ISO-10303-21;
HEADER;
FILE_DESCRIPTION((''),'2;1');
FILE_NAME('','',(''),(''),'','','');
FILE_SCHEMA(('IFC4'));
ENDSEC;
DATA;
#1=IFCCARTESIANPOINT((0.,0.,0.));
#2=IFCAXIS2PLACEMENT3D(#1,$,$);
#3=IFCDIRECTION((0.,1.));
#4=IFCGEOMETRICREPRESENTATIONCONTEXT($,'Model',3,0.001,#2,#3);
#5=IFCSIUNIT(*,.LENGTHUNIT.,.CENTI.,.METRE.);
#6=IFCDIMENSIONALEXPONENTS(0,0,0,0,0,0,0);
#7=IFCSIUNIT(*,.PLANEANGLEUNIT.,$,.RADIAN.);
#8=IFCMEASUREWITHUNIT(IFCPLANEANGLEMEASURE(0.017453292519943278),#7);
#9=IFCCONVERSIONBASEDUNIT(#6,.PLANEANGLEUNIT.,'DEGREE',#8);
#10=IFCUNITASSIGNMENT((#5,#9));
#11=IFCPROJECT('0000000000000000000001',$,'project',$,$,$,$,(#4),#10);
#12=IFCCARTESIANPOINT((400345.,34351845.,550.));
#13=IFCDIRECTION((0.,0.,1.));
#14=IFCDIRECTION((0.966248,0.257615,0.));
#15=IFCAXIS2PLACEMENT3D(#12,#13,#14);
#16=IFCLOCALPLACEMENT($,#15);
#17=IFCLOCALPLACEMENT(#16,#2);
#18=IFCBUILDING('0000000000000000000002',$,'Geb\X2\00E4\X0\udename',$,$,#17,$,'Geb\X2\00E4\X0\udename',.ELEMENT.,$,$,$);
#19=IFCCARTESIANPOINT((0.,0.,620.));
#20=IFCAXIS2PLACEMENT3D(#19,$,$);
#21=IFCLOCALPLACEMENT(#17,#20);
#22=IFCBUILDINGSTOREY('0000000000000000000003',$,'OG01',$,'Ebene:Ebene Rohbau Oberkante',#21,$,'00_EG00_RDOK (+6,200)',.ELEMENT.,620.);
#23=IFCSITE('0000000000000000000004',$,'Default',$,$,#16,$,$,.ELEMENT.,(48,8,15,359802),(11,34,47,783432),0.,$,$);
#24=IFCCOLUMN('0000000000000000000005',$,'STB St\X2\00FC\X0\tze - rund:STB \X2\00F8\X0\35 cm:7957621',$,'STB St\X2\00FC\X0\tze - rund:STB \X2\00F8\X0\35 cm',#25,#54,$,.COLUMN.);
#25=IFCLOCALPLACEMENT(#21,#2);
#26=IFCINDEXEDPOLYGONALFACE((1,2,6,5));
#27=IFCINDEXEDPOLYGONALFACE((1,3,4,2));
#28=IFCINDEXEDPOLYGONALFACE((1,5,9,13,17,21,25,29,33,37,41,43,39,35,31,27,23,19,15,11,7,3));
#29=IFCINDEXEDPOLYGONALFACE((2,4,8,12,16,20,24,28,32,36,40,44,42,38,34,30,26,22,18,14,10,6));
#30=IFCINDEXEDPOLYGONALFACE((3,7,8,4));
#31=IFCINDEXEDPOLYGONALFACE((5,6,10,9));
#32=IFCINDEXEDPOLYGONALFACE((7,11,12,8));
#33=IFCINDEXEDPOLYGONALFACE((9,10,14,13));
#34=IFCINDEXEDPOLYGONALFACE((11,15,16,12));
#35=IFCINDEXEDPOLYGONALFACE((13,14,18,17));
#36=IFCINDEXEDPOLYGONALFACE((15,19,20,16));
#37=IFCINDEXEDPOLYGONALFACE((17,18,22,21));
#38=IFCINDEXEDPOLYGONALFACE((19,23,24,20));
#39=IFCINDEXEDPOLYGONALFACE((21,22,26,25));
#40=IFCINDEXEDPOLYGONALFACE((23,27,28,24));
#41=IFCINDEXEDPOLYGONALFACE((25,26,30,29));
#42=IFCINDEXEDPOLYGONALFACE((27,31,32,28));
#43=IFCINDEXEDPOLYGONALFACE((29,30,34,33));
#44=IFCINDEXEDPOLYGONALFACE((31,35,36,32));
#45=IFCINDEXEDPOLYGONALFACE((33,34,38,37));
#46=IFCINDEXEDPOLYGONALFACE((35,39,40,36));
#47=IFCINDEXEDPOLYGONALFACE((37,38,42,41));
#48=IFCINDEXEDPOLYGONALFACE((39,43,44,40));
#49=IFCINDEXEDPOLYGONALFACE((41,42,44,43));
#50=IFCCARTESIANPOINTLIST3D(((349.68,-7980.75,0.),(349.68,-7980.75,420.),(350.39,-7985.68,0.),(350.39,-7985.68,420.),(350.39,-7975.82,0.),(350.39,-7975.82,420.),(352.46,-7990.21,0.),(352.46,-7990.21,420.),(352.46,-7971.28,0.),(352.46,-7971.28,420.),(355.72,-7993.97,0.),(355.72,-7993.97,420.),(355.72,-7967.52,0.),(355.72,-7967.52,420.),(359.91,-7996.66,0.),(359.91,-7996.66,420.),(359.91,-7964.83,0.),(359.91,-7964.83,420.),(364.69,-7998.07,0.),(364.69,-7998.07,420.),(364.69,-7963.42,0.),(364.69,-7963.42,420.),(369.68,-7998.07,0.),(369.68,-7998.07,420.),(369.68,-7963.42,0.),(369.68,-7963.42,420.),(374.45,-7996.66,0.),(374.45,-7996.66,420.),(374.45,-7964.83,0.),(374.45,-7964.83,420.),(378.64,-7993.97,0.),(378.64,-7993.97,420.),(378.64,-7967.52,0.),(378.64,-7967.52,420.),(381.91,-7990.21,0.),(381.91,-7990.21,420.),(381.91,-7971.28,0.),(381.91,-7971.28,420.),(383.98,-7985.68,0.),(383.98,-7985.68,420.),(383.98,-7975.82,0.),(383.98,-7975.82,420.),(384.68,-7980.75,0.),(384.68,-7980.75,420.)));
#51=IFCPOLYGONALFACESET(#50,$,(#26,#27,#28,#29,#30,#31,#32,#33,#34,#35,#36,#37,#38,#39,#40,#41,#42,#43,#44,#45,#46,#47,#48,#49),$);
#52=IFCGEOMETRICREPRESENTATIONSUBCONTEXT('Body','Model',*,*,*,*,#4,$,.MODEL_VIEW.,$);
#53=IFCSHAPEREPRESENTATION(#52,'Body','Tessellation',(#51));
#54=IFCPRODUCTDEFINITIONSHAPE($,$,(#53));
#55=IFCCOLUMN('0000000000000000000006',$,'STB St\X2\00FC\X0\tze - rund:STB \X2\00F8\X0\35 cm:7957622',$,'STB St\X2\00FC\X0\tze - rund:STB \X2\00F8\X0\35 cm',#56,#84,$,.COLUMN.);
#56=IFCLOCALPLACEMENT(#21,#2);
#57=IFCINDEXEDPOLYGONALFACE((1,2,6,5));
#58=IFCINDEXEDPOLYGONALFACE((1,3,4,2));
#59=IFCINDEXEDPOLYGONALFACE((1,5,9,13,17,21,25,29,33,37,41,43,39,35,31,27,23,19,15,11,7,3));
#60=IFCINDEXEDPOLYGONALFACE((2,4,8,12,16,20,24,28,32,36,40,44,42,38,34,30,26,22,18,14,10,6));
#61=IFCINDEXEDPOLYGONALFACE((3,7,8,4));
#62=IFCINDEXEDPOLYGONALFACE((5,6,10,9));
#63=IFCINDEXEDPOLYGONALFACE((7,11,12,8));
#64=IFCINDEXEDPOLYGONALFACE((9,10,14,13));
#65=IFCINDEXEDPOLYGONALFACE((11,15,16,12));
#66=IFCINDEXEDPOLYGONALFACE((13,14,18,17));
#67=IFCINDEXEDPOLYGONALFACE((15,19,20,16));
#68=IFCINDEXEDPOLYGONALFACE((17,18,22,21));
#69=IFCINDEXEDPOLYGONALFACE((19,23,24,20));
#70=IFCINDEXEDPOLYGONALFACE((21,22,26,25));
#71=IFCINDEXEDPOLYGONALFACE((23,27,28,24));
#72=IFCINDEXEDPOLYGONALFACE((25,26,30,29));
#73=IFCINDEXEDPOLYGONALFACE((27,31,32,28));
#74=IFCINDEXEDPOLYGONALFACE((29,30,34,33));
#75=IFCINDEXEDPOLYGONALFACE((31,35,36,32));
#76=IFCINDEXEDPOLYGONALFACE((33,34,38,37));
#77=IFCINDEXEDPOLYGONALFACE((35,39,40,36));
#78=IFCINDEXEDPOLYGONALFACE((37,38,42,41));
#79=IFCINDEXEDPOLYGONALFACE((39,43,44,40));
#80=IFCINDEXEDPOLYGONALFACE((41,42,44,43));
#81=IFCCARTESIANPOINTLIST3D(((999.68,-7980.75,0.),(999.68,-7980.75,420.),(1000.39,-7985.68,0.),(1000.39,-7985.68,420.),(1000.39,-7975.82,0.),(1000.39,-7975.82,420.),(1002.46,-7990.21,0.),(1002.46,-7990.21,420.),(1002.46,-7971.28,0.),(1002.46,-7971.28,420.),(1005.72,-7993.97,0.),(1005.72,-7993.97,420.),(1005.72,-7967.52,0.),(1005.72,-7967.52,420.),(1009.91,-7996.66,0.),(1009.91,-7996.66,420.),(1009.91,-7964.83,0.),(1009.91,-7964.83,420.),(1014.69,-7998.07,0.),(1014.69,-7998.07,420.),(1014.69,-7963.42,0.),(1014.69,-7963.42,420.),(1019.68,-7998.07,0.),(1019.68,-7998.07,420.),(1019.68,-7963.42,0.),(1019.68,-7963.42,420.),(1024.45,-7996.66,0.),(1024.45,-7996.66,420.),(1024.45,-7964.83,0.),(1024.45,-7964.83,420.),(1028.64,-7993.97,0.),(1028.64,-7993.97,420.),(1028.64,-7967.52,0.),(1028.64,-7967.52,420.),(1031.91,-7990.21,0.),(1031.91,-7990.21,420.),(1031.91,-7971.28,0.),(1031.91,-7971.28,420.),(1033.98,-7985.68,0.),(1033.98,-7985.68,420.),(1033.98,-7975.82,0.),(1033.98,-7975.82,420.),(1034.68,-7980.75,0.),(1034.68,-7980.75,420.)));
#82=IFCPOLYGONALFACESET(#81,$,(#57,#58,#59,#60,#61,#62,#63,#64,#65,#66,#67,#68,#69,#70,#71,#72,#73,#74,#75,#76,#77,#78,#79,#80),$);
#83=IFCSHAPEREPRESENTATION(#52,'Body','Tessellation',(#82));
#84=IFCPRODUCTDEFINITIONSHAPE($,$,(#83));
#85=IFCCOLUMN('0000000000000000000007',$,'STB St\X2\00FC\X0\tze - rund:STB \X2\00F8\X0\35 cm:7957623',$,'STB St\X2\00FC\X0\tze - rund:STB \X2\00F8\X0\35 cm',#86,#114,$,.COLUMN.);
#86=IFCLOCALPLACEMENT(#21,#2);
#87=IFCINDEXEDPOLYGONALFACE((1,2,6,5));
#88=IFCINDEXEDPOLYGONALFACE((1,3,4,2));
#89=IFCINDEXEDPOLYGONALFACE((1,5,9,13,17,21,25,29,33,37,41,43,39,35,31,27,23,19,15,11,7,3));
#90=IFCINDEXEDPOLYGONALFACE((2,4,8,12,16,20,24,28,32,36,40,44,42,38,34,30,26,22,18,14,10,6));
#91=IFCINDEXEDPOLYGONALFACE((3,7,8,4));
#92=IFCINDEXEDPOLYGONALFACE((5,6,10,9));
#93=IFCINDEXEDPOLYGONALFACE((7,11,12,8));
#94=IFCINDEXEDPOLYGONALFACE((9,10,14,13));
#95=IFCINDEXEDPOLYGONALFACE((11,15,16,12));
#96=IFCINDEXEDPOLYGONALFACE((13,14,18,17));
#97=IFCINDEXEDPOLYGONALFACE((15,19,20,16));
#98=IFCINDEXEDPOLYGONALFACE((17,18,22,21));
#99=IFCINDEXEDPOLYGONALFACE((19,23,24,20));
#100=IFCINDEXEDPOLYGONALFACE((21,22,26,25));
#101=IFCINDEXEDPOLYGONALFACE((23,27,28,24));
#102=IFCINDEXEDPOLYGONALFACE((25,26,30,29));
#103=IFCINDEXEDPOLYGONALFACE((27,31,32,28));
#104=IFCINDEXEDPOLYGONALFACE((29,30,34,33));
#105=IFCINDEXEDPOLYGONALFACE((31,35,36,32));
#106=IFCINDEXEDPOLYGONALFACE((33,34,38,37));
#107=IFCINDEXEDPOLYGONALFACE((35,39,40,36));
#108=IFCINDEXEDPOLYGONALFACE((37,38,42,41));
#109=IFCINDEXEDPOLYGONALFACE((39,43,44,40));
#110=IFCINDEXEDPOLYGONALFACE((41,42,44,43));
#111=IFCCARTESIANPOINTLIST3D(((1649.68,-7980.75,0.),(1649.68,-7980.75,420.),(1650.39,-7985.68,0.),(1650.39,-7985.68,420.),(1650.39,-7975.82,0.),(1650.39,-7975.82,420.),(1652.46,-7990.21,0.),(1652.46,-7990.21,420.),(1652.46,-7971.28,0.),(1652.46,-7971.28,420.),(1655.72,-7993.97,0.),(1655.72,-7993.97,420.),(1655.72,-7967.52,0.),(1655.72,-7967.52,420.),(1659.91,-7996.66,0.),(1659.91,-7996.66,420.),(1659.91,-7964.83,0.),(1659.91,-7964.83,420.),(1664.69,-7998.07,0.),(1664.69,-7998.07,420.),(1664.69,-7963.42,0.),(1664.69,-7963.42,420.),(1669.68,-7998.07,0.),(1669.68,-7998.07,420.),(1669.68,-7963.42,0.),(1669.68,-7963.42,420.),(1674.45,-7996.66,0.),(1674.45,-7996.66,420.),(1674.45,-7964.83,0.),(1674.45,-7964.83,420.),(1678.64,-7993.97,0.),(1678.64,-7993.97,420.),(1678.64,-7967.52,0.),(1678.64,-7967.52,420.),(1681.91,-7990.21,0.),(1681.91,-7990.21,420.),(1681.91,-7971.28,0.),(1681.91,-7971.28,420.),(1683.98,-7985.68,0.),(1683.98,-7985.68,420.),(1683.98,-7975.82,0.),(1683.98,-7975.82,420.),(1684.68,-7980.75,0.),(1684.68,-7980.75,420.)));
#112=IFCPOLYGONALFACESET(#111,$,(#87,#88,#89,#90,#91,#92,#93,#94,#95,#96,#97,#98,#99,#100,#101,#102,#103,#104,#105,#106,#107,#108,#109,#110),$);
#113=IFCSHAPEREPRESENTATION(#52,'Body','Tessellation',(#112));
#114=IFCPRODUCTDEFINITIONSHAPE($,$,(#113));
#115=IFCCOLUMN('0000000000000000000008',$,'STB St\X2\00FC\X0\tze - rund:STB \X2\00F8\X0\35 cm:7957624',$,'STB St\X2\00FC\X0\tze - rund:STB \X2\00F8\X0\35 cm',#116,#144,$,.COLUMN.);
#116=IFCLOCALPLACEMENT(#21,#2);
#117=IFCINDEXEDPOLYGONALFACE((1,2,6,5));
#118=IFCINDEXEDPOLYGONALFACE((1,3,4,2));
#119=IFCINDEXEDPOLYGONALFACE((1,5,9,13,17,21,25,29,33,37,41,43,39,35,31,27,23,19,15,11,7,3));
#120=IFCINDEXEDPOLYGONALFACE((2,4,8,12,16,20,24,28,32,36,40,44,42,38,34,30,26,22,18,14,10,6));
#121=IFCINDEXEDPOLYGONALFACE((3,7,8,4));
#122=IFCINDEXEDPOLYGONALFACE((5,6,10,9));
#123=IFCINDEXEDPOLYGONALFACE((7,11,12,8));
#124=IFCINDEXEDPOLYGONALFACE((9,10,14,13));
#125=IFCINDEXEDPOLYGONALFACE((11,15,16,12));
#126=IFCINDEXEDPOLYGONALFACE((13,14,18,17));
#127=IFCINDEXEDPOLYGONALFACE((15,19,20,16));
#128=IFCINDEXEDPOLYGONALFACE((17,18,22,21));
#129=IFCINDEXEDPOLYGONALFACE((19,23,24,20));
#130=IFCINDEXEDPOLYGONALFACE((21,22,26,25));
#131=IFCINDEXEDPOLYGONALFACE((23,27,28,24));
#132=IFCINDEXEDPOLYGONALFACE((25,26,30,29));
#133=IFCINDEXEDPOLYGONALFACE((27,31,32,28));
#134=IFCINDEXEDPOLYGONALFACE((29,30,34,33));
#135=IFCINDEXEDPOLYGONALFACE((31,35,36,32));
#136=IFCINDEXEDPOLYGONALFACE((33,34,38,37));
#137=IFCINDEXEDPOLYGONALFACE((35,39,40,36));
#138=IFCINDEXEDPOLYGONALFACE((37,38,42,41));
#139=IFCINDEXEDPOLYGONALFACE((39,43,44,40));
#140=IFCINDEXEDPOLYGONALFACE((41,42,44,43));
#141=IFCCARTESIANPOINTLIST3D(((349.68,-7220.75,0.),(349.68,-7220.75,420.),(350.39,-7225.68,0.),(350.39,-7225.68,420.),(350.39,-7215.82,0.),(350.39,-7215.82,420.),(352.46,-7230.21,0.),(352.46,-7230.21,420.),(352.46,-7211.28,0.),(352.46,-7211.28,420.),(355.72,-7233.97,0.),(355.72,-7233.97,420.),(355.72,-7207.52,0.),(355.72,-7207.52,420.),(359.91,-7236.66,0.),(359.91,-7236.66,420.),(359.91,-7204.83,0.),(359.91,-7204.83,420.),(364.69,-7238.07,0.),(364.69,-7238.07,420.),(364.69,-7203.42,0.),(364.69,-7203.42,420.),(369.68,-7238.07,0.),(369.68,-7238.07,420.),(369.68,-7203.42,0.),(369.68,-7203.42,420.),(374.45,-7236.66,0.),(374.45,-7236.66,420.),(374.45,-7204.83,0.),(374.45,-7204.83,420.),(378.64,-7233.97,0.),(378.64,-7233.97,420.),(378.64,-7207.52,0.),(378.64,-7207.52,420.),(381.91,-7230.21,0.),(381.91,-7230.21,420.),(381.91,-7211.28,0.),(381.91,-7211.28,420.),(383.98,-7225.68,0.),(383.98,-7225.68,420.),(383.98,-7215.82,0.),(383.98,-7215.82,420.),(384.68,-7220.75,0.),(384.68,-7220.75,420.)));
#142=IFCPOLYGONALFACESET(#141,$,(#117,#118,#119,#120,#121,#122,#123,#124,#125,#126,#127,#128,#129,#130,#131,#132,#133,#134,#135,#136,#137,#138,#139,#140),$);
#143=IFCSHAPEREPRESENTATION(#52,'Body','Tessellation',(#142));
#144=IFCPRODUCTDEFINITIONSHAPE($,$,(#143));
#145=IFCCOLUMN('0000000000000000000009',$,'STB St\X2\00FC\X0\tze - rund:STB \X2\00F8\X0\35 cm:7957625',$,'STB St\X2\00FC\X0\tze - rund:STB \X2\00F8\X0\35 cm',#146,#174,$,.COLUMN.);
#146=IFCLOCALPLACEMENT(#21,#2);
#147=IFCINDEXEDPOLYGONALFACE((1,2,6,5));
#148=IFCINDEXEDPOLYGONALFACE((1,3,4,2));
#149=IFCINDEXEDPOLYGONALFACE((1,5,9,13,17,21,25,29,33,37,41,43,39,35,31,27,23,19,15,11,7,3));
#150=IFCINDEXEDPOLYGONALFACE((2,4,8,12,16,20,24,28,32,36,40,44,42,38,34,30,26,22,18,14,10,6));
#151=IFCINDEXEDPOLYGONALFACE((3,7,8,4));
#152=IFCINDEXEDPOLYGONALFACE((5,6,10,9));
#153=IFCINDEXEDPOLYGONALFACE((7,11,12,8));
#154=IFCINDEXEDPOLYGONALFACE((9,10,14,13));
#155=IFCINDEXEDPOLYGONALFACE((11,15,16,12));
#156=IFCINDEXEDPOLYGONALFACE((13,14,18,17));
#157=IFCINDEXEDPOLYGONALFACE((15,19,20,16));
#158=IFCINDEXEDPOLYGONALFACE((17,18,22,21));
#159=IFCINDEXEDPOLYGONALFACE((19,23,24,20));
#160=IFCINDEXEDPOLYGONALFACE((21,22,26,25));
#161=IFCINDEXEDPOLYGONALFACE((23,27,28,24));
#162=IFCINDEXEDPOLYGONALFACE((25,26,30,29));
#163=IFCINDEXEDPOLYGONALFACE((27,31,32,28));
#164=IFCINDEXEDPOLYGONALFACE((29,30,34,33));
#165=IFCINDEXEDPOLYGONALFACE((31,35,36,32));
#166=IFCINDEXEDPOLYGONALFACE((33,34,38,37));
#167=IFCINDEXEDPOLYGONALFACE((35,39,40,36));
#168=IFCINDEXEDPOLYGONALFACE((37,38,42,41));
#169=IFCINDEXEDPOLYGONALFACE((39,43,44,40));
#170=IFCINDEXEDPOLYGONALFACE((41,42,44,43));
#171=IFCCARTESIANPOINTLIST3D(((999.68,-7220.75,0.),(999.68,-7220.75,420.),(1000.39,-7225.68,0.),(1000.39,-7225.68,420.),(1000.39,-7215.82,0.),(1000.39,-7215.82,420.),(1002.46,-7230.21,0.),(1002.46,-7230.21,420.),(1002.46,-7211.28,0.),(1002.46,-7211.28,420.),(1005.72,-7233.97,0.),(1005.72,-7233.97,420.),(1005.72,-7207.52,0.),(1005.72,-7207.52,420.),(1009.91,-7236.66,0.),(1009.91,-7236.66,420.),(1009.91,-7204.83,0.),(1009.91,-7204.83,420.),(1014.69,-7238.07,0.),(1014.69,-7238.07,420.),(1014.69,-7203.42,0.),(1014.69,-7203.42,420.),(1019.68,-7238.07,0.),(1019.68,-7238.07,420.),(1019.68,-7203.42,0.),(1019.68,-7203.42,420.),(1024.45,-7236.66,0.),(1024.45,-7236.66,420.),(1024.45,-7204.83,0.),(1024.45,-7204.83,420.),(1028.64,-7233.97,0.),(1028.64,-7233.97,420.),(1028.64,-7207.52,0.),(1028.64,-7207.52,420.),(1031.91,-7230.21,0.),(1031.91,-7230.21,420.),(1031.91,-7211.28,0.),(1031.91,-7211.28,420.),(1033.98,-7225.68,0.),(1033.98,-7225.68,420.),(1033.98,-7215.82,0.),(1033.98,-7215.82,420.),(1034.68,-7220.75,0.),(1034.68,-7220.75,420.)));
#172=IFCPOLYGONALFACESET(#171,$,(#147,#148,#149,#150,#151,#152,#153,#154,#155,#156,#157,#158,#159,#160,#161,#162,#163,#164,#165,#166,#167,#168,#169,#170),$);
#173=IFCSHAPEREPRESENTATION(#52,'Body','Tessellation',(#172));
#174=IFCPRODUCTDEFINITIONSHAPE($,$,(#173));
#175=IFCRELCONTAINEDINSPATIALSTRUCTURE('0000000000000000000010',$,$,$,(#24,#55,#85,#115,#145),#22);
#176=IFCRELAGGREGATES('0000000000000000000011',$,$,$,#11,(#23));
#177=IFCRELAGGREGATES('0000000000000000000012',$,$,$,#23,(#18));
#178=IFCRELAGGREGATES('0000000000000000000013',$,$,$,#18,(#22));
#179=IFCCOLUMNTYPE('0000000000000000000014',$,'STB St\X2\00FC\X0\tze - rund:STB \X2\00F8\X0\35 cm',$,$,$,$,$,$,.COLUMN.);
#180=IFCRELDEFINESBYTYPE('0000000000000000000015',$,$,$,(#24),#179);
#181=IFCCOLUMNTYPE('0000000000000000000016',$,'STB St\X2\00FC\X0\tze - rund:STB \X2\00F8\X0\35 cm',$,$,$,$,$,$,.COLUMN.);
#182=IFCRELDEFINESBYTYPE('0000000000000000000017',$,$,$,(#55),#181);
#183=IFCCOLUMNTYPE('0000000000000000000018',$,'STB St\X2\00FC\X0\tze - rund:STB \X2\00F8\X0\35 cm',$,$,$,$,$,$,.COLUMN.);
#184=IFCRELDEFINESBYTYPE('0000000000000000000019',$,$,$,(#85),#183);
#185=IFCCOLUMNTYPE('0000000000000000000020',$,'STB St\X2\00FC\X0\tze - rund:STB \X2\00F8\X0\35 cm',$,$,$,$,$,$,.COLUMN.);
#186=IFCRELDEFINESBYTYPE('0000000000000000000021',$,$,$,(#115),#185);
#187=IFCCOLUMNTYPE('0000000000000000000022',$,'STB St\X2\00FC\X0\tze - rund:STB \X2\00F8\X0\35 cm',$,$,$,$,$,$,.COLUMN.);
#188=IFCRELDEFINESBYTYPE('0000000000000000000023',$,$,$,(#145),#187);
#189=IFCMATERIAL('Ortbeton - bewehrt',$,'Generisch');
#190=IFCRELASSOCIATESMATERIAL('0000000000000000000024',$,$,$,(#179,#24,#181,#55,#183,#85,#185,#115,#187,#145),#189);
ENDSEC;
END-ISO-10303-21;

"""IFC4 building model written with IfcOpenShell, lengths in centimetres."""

from ifc_helpers import new_model, entity, si_unit, converted_unit, direction, frame, origin, place, context, subcontext, project, spatial, arc, indexed_curve, outline, extrude, source, transform, mapped, material, type_object, type_shapes, element, save


model = new_model("IFC4")

# Units and contexts
model_context = context("Model", 3, precision=0.001, world=origin(), true_north=direction((0.0, 1.0)))
body_context = subcontext(model_context, "Body", "Model", "MODEL_VIEW")
ifc_project = project(units=[si_unit("LENGTHUNIT", "METRE", prefix="CENTI"), converted_unit("PLANEANGLEUNIT", "DEGREE", entity("IfcPlaneAngleMeasure", 0.017453292519943278), si_unit("PLANEANGLEUNIT", "RADIAN"), dimensions=[0, 0, 0, 0, 0, 0, 0])], contexts=[model_context])

# Site, building, storey
site_placement = place(None, frame((400345.0, 34351845.0, 550.0), z_axis=(0.0, 0.0, 1.0), x_axis=(0.966248, 0.257615, 0.0)))
site = spatial("IfcSite", under=ifc_project, at=site_placement, Name="Default", CompositionType="ELEMENT", RefLatitude=(48, 8, 15, 359802), RefLongitude=(11, 34, 47, 783432), RefElevation=0.0)
building_placement = place(site_placement, origin())
building = spatial("IfcBuilding", under=site, at=building_placement, Name="Gebäudename", LongName="Gebäudename", CompositionType="ELEMENT")
storey_placement = place(building_placement, frame((0.0, 0.0, 620.0)))
storey = spatial("IfcBuildingStorey", under=building, at=storey_placement, Name="OG01", ObjectType="Ebene:Ebene Rohbau Oberkante", LongName="00_EG00_RDOK (+6,200)", CompositionType="ELEMENT", Elevation=620.0)

# Columns
ifc_material = material(Name="Ortbeton - bewehrt", Category="Generisch")
column_type_1 = type_object("IfcColumnType", Name="STB Stütze - rund:STB ø35 cm", PredefinedType="COLUMN", material=ifc_material)
shared_shape_1 = source(origin(), body_context, "Body", "SweptSolid", [
    extrude(outline(indexed_curve([(-17.5, 0.0), (0.0, -17.5), (17.5, 0.0), (0.0, 17.5)], segments=[arc(1, 2, 3), arc(3, 4, 1)], self_intersect=False)), frame((367.18, -7980.75, 620.0)), (0.0, 0.0, 1.0), 420.0),
])
type_shapes(column_type_1, [shared_shape_1])
column_1_placement = place(storey_placement, frame((0.0, 0.0, -620.0)))
element("IfcColumn", 1, at=column_1_placement, inside=storey, type_object=column_type_1, material=ifc_material, Name="STB Stütze - rund:STB ø35 cm:7957621", ObjectType="STB Stütze - rund:STB ø35 cm", PredefinedType="COLUMN", context=body_context, shape_type="MappedRepresentation", body=[
    mapped(shared_shape_1, transform((0.0, 0.0, 0.0), scale=1.0)),
])
column_type_2 = type_object("IfcColumnType", Name="STB Stütze - rund:STB ø35 cm", PredefinedType="COLUMN", material=ifc_material)
shared_shape_2 = source(origin(), body_context, "Body", "SweptSolid", [
    extrude(outline(indexed_curve([(-17.5, 0.0), (0.0, -17.5), (17.5, 0.0), (0.0, 17.5)], segments=[arc(1, 2, 3), arc(3, 4, 1)], self_intersect=False)), frame((1017.18, -7980.75, 620.0)), (0.0, 0.0, 1.0), 420.0),
])
type_shapes(column_type_2, [shared_shape_2])
column_2_placement = place(storey_placement, frame((0.0, 0.0, -620.0)))
element("IfcColumn", 2, at=column_2_placement, inside=storey, type_object=column_type_2, material=ifc_material, Name="STB Stütze - rund:STB ø35 cm:7957622", ObjectType="STB Stütze - rund:STB ø35 cm", PredefinedType="COLUMN", context=body_context, shape_type="MappedRepresentation", body=[
    mapped(shared_shape_2, transform((0.0, 0.0, 0.0), scale=1.0)),
])
column_type_3 = type_object("IfcColumnType", Name="STB Stütze - rund:STB ø35 cm", PredefinedType="COLUMN", material=ifc_material)
shared_shape_3 = source(origin(), body_context, "Body", "SweptSolid", [
    extrude(outline(indexed_curve([(-17.5, 0.0), (0.0, -17.5), (17.5, 0.0), (0.0, 17.5)], segments=[arc(1, 2, 3), arc(3, 4, 1)], self_intersect=False)), frame((1667.18, -7980.75, 620.0)), (0.0, 0.0, 1.0), 420.0),
])
type_shapes(column_type_3, [shared_shape_3])
column_3_placement = place(storey_placement, frame((0.0, 0.0, -620.0)))
element("IfcColumn", 3, at=column_3_placement, inside=storey, type_object=column_type_3, material=ifc_material, Name="STB Stütze - rund:STB ø35 cm:7957623", ObjectType="STB Stütze - rund:STB ø35 cm", PredefinedType="COLUMN", context=body_context, shape_type="MappedRepresentation", body=[
    mapped(shared_shape_3, transform((0.0, 0.0, 0.0), scale=1.0)),
])
column_type_4 = type_object("IfcColumnType", Name="STB Stütze - rund:STB ø35 cm", PredefinedType="COLUMN", material=ifc_material)
shared_shape_4 = source(origin(), body_context, "Body", "SweptSolid", [
    extrude(outline(indexed_curve([(-17.5, 0.0), (0.0, -17.5), (17.5, 0.0), (0.0, 17.5)], segments=[arc(1, 2, 3), arc(3, 4, 1)], self_intersect=False)), frame((367.18, -7220.75, 620.0)), (0.0, 0.0, 1.0), 420.0),
])
type_shapes(column_type_4, [shared_shape_4])
column_4_placement = place(storey_placement, frame((0.0, 0.0, -620.0)))
element("IfcColumn", 4, at=column_4_placement, inside=storey, type_object=column_type_4, material=ifc_material, Name="STB Stütze - rund:STB ø35 cm:7957624", ObjectType="STB Stütze - rund:STB ø35 cm", PredefinedType="COLUMN", context=body_context, shape_type="MappedRepresentation", body=[
    mapped(shared_shape_4, transform((0.0, 0.0, 0.0), scale=1.0)),
])
column_type_5 = type_object("IfcColumnType", Name="STB Stütze - rund:STB ø35 cm", PredefinedType="COLUMN", material=ifc_material)
shared_shape_5 = source(origin(), body_context, "Body", "SweptSolid", [
    extrude(outline(indexed_curve([(-17.5, 0.0), (0.0, -17.5), (17.5, 0.0), (0.0, 17.5)], segments=[arc(1, 2, 3), arc(3, 4, 1)], self_intersect=False)), frame((1017.18, -7220.75, 620.0)), (0.0, 0.0, 1.0), 420.0),
])
type_shapes(column_type_5, [shared_shape_5])
column_5_placement = place(storey_placement, frame((0.0, 0.0, -620.0)))
element("IfcColumn", 5, at=column_5_placement, inside=storey, type_object=column_type_5, material=ifc_material, Name="STB Stütze - rund:STB ø35 cm:7957625", ObjectType="STB Stütze - rund:STB ø35 cm", PredefinedType="COLUMN", context=body_context, shape_type="MappedRepresentation", body=[
    mapped(shared_shape_5, transform((0.0, 0.0, 0.0), scale=1.0)),
])

save(model, "model.ifc")
